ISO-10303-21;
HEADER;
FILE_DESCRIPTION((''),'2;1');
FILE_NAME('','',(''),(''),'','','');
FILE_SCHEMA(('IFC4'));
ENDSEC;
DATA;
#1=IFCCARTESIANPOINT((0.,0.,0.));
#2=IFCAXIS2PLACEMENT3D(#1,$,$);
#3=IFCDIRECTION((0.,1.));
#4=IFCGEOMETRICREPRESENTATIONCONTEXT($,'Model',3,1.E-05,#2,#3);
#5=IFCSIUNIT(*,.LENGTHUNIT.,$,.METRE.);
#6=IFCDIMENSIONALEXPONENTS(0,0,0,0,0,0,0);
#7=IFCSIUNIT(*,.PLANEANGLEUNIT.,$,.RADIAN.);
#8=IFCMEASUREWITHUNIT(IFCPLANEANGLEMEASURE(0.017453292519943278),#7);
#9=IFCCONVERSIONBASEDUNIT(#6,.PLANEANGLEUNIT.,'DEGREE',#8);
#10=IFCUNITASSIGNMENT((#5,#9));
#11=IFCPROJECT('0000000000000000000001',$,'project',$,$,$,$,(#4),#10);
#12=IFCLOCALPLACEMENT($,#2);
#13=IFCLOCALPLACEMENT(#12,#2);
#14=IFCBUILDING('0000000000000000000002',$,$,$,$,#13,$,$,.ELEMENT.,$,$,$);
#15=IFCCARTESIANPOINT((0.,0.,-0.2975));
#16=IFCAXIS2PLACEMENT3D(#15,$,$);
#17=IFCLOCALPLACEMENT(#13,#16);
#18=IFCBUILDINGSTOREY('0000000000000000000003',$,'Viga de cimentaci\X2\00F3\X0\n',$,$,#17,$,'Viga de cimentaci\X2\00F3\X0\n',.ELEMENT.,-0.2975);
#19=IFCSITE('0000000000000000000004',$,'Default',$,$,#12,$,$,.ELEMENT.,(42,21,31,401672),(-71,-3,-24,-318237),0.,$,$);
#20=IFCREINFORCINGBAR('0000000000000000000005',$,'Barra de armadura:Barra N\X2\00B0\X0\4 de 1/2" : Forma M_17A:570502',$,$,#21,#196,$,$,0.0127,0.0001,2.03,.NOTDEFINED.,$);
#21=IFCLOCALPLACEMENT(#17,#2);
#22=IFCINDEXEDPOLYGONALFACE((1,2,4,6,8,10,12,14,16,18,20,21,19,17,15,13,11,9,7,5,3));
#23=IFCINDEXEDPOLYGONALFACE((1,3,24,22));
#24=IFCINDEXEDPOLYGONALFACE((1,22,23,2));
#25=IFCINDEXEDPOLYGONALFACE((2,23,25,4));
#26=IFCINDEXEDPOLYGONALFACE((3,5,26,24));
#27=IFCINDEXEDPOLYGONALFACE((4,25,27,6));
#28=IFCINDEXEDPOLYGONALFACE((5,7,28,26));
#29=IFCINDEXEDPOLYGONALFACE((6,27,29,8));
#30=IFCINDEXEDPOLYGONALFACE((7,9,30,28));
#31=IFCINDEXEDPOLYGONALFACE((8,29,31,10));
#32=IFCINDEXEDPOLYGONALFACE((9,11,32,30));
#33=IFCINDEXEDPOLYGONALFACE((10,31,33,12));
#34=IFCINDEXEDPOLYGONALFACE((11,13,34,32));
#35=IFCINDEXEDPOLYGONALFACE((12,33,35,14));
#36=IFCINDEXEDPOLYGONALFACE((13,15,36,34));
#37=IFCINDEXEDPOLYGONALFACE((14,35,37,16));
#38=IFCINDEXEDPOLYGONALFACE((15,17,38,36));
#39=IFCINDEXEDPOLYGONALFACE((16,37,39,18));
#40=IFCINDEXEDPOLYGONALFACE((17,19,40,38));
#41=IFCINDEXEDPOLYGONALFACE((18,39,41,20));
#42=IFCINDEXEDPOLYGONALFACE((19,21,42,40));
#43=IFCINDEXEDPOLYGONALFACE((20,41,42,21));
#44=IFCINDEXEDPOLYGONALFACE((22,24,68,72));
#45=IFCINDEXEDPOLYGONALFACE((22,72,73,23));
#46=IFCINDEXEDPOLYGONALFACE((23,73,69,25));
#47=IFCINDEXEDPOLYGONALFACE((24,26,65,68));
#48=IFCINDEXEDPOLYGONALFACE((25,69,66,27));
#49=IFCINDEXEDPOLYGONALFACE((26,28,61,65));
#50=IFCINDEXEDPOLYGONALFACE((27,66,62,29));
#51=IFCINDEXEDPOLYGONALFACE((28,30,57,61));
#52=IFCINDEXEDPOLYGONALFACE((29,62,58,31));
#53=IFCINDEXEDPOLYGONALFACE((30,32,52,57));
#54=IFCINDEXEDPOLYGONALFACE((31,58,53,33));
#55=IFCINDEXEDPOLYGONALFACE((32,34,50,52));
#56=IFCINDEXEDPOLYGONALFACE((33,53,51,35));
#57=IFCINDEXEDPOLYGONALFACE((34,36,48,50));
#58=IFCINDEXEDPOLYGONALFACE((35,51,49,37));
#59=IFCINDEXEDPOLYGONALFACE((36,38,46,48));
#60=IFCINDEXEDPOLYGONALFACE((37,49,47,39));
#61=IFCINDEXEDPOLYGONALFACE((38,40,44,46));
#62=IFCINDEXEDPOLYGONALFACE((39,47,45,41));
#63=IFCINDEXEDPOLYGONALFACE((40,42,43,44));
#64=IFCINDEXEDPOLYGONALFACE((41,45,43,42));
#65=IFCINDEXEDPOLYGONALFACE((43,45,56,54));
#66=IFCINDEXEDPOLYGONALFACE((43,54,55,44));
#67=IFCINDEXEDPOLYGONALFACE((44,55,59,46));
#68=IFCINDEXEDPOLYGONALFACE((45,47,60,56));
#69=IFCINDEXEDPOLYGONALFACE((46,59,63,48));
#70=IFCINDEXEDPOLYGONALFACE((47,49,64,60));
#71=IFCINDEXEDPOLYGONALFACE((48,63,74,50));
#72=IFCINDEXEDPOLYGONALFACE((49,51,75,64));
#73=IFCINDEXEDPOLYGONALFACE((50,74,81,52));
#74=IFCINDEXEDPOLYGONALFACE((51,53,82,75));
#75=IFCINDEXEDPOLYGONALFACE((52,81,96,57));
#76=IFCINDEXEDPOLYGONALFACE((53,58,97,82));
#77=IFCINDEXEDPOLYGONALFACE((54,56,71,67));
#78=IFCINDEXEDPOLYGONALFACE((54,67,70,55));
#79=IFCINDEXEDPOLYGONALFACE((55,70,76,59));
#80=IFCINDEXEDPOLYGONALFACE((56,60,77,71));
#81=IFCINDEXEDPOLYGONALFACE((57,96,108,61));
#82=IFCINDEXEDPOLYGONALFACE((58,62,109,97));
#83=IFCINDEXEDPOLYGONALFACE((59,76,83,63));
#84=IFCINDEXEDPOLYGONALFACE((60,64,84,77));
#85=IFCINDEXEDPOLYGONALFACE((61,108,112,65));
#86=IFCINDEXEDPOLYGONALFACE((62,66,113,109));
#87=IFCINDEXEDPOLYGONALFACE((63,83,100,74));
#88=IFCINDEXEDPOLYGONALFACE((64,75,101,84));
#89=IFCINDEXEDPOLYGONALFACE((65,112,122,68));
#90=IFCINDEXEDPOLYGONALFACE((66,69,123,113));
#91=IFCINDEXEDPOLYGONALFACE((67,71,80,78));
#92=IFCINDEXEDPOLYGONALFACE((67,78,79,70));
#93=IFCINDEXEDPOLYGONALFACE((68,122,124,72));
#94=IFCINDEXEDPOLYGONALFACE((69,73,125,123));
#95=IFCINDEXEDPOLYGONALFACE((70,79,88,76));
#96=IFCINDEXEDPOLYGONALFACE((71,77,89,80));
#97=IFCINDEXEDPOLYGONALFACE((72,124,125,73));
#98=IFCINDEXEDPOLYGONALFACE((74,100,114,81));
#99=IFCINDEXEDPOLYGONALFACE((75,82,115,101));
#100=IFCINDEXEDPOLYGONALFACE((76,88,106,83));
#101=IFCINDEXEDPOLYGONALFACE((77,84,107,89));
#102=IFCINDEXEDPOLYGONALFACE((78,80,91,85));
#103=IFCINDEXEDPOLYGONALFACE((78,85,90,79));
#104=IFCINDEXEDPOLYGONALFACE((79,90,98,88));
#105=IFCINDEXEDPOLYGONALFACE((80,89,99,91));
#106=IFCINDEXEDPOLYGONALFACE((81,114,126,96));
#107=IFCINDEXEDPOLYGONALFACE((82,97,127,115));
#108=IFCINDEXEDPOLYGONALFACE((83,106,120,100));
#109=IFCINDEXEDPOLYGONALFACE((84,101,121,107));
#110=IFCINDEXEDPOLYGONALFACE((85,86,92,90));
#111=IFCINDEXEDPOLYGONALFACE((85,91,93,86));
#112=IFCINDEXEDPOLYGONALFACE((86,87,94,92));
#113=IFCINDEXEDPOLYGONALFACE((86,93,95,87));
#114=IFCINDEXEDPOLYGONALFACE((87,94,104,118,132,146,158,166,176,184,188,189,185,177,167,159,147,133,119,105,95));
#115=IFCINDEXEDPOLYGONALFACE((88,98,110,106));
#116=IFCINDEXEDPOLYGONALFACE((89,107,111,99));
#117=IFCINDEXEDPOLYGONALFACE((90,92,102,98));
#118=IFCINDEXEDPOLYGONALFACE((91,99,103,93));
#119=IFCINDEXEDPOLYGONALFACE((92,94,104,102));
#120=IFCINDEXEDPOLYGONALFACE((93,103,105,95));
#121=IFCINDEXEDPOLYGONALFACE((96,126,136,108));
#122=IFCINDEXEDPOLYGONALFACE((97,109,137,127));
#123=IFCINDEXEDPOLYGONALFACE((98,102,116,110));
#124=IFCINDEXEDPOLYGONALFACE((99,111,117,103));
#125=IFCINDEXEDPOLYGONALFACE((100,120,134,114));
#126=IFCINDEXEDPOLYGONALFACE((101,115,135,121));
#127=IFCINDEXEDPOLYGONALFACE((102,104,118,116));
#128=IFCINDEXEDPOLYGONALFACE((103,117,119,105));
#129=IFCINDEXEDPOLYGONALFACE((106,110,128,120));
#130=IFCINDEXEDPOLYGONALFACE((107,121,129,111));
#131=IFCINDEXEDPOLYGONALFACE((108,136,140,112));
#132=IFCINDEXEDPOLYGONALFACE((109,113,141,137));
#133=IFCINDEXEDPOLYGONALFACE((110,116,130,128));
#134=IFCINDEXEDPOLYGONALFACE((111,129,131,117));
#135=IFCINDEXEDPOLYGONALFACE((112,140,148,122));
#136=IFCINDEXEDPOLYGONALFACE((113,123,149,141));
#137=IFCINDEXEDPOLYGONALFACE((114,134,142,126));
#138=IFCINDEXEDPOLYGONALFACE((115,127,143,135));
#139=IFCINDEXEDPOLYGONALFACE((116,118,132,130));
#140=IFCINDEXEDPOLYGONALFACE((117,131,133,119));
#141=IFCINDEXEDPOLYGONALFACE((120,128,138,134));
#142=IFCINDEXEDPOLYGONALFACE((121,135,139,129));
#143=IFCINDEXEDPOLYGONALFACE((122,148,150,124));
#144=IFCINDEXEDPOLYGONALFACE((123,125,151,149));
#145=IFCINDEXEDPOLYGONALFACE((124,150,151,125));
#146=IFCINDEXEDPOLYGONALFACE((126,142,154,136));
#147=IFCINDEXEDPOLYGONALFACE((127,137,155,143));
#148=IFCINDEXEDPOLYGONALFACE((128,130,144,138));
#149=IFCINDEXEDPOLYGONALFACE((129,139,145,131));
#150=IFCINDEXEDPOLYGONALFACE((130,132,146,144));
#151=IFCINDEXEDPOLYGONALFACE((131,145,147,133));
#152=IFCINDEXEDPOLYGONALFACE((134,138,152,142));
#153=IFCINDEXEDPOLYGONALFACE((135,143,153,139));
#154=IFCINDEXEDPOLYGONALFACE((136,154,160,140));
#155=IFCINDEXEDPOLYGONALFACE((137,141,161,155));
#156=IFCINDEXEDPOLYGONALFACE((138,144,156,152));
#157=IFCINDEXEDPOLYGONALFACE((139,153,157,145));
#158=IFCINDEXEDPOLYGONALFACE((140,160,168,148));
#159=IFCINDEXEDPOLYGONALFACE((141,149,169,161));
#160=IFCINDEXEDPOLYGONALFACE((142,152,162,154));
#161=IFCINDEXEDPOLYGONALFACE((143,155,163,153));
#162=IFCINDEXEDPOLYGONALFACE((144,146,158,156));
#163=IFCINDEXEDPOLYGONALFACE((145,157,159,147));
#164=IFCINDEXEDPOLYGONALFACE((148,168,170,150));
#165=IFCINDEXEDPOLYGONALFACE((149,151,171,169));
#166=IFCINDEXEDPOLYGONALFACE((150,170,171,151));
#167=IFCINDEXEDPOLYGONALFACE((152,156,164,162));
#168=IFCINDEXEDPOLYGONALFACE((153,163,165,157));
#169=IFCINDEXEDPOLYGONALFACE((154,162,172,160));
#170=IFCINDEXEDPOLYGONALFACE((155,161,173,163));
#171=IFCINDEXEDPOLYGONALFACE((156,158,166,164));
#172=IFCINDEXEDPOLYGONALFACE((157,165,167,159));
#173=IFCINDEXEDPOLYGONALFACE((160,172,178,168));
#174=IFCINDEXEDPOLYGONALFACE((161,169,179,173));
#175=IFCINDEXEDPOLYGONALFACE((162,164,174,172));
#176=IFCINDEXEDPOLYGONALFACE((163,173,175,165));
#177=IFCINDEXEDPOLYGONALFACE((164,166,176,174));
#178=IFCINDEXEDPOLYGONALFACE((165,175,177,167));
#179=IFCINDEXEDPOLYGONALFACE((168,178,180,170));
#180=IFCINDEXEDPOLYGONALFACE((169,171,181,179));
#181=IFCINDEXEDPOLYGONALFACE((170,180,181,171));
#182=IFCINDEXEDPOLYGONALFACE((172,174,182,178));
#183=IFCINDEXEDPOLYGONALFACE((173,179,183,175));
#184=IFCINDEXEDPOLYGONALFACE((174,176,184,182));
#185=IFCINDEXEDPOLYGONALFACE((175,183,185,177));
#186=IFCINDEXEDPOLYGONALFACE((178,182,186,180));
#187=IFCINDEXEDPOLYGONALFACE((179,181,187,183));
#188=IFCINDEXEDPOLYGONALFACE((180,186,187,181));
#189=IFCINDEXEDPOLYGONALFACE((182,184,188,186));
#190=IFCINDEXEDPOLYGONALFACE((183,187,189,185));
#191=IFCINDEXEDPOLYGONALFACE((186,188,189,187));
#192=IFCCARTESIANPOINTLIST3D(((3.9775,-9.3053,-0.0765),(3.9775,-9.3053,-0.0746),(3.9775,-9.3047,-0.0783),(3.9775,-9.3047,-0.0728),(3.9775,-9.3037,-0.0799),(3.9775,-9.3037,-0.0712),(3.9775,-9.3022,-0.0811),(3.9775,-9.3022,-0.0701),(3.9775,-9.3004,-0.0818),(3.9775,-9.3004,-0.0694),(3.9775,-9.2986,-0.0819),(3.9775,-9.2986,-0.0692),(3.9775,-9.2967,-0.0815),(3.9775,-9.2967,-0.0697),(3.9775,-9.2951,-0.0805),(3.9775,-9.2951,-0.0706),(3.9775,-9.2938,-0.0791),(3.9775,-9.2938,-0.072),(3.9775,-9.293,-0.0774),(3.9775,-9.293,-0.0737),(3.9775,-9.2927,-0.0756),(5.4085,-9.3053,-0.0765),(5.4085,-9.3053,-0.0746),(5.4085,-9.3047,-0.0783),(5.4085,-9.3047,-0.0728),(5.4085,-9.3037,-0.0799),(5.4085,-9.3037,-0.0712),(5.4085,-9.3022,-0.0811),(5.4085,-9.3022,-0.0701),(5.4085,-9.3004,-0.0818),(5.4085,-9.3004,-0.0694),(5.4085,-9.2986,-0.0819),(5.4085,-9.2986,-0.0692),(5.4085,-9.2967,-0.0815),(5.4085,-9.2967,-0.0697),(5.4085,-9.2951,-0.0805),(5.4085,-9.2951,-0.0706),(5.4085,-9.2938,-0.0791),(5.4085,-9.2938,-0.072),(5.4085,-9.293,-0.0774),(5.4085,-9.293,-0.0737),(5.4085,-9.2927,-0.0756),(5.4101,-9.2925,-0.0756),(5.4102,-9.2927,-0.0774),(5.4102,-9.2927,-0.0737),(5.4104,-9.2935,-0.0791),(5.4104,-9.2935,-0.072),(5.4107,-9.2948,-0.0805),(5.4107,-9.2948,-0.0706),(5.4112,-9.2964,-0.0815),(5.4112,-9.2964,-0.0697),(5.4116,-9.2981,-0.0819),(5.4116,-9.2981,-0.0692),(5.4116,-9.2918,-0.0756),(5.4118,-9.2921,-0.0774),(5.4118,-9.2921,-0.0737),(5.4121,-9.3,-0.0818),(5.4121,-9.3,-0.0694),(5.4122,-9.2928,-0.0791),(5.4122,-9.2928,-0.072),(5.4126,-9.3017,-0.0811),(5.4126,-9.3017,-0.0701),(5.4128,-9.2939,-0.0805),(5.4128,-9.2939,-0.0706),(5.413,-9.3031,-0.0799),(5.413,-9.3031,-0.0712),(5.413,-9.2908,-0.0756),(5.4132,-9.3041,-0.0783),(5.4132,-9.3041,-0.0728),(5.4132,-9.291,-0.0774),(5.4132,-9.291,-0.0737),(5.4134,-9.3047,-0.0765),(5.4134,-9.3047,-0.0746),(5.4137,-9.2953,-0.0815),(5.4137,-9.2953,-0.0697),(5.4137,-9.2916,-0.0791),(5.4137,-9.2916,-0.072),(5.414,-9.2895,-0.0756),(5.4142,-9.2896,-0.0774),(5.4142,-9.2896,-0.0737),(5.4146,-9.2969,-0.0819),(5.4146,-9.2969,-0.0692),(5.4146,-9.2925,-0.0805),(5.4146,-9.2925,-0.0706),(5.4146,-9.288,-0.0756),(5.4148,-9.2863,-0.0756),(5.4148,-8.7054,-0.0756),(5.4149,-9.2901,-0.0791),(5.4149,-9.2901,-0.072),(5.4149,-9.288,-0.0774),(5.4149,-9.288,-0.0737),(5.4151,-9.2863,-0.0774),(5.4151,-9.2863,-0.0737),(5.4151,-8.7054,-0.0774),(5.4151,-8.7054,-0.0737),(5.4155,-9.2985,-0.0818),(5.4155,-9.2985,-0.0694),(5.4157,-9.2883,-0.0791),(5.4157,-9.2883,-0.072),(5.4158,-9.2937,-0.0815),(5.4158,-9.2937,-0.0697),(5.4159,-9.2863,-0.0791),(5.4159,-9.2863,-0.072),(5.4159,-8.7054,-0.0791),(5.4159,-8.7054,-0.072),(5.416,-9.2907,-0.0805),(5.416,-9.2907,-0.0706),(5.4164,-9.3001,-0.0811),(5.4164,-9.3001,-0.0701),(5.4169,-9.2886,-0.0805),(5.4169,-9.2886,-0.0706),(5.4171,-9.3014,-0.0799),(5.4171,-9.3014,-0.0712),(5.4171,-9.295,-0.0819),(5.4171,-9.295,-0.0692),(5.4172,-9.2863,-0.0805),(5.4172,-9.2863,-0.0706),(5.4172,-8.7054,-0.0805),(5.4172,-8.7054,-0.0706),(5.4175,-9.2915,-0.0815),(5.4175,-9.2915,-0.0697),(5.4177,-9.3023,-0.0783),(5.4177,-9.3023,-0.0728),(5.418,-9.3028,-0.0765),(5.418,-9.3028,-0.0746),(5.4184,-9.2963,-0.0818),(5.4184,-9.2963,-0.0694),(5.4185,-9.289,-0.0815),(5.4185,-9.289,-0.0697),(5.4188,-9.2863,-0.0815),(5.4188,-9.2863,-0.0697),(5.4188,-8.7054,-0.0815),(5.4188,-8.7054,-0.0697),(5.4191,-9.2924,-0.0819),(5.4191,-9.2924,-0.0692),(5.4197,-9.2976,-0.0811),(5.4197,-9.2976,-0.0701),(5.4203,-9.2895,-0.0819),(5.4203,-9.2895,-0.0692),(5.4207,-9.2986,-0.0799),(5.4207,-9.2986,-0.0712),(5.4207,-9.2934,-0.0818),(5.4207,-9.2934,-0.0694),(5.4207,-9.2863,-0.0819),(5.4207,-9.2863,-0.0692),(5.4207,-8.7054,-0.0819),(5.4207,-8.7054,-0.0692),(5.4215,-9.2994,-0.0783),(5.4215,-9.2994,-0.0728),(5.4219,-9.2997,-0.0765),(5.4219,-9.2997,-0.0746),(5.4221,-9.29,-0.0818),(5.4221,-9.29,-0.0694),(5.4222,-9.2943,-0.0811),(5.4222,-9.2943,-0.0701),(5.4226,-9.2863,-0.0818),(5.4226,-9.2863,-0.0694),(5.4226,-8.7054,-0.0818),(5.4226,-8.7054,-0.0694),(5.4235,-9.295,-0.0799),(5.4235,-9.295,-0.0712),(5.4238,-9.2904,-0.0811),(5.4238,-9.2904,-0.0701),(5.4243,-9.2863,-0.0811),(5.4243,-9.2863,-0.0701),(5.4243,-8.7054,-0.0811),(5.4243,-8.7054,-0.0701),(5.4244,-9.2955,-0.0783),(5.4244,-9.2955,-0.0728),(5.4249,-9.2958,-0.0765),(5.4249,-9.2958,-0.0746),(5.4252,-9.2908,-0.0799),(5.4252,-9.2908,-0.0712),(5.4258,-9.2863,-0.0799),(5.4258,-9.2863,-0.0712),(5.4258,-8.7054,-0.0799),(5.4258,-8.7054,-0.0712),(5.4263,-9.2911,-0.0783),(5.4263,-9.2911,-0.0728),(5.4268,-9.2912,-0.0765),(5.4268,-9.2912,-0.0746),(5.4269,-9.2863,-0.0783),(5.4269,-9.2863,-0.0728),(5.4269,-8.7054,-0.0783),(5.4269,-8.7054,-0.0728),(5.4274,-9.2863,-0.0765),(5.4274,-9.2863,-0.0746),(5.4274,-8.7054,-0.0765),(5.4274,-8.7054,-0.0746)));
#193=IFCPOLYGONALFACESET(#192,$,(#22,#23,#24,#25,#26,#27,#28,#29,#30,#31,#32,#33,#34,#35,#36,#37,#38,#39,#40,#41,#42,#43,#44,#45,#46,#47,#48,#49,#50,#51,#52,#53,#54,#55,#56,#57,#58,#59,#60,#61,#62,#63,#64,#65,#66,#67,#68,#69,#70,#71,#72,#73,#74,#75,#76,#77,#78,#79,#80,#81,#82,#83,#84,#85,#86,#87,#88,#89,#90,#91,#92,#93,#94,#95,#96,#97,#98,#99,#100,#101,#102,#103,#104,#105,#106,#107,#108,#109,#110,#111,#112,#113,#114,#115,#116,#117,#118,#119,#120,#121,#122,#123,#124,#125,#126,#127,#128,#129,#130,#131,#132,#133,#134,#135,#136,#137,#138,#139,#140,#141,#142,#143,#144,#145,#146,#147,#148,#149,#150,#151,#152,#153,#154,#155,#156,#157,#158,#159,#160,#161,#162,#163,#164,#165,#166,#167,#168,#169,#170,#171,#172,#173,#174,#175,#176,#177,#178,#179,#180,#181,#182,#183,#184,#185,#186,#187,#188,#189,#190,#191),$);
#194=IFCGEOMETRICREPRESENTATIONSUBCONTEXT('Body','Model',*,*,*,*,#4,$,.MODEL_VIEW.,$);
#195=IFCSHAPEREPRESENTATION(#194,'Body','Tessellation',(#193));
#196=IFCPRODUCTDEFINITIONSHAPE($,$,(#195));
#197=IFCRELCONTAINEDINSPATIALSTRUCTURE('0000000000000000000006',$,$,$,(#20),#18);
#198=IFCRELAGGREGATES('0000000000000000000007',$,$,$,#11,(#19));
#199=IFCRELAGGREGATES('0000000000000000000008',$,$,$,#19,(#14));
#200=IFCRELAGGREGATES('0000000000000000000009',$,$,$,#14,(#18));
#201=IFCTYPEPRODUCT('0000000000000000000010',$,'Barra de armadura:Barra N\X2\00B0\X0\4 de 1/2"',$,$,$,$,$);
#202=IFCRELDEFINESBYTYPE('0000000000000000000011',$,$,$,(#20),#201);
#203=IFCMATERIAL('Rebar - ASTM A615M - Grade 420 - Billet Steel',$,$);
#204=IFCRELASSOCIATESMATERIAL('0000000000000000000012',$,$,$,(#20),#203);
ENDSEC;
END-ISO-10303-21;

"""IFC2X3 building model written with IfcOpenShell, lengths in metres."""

from ifc_helpers import new_model, entity, si_unit, converted_unit, direction, frame, origin, place, context, subcontext, project, spatial, material, type_object, element, save


model = new_model("IFC2X3")

# Units and contexts
model_context = context("Model", 3, precision=1e-05, world=origin(), true_north=direction((0.0, 1.0)))
body_context = subcontext(model_context, "Body", "Model", "MODEL_VIEW")
ifc_project = project(units=[si_unit("LENGTHUNIT", "METRE"), converted_unit("PLANEANGLEUNIT", "DEGREE", entity("IfcPlaneAngleMeasure", 0.017453292519943278), si_unit("PLANEANGLEUNIT", "RADIAN"), dimensions=[0, 0, 0, 0, 0, 0, 0])], contexts=[model_context])

# Site, building, storey
site_placement = place(None, origin())
site = spatial("IfcSite", under=ifc_project, at=site_placement, Name="Default", CompositionType="ELEMENT", RefLatitude=(42, 21, 31, 401672), RefLongitude=(-71, -3, -24, -318237), RefElevation=0.0)
building_placement = place(site_placement, origin())
building = spatial("IfcBuilding", under=site, at=building_placement, CompositionType="ELEMENT")
storey_placement = place(building_placement, frame((0.0, 0.0, -0.2975)))
storey = spatial("IfcBuildingStorey", under=building, at=storey_placement, Name="Viga de cimentación", LongName="Viga de cimentación", CompositionType="ELEMENT", Elevation=-0.2975)

# Reinforcing bar
ifc_material = material(Name="Rebar - ASTM A615M - Grade 420 - Billet Steel")
type_product_1 = type_object("IfcTypeProduct", Name="Barra de armadura:Barra N°4 de 1/2\"")
reinforcing_bar_1_placement = place(storey_placement, origin())
element("IfcReinforcingBar", 1, at=reinforcing_bar_1_placement, inside=storey, type_object=type_product_1, material=ifc_material, Name="Barra de armadura:Barra N°4 de 1/2\" : Forma M_17A:570502", BarLength=2.03, BarRole="NOTDEFINED", CrossSectionArea=0.0001, NominalDiameter=0.0127, context=body_context, shape_type="AdvancedSweptSolid", body=[
    entity("IfcSweptDiskSolid", entity("IfcCompositeCurve", [entity("IfcCompositeCurveSegment", "CONTINUOUS", True, entity("IfcPolyline", [entity("IfcCartesianPoint", [5.4212, -8.7054, -0.0756]), entity("IfcCartesianPoint", [5.4212, -9.2863, -0.0756])])), entity("IfcCompositeCurveSegment", "CONTINUOUS", True, entity("IfcTrimmedCurve", entity("IfcCircle", entity("IfcAxis2Placement3D", entity("IfcCartesianPoint", [5.4085, -9.2863, -0.0756]), entity("IfcDirection", [0.0, 0.0, -1.0]), entity("IfcDirection", [0.0, -1.0, 0.0])), 0.0127), [entity("IfcParameterValue", 270.0)], [entity("IfcParameterValue", 360.0)], True, "PARAMETER")), entity("IfcCompositeCurveSegment", "CONTINUOUS", True, entity("IfcPolyline", [entity("IfcCartesianPoint", [5.4085, -9.299, -0.0756]), entity("IfcCartesianPoint", [3.9775, -9.299, -0.0756])]))], False), 0.0063, None, 0.0, 92.0),
])

save(model, "model.ifc")
